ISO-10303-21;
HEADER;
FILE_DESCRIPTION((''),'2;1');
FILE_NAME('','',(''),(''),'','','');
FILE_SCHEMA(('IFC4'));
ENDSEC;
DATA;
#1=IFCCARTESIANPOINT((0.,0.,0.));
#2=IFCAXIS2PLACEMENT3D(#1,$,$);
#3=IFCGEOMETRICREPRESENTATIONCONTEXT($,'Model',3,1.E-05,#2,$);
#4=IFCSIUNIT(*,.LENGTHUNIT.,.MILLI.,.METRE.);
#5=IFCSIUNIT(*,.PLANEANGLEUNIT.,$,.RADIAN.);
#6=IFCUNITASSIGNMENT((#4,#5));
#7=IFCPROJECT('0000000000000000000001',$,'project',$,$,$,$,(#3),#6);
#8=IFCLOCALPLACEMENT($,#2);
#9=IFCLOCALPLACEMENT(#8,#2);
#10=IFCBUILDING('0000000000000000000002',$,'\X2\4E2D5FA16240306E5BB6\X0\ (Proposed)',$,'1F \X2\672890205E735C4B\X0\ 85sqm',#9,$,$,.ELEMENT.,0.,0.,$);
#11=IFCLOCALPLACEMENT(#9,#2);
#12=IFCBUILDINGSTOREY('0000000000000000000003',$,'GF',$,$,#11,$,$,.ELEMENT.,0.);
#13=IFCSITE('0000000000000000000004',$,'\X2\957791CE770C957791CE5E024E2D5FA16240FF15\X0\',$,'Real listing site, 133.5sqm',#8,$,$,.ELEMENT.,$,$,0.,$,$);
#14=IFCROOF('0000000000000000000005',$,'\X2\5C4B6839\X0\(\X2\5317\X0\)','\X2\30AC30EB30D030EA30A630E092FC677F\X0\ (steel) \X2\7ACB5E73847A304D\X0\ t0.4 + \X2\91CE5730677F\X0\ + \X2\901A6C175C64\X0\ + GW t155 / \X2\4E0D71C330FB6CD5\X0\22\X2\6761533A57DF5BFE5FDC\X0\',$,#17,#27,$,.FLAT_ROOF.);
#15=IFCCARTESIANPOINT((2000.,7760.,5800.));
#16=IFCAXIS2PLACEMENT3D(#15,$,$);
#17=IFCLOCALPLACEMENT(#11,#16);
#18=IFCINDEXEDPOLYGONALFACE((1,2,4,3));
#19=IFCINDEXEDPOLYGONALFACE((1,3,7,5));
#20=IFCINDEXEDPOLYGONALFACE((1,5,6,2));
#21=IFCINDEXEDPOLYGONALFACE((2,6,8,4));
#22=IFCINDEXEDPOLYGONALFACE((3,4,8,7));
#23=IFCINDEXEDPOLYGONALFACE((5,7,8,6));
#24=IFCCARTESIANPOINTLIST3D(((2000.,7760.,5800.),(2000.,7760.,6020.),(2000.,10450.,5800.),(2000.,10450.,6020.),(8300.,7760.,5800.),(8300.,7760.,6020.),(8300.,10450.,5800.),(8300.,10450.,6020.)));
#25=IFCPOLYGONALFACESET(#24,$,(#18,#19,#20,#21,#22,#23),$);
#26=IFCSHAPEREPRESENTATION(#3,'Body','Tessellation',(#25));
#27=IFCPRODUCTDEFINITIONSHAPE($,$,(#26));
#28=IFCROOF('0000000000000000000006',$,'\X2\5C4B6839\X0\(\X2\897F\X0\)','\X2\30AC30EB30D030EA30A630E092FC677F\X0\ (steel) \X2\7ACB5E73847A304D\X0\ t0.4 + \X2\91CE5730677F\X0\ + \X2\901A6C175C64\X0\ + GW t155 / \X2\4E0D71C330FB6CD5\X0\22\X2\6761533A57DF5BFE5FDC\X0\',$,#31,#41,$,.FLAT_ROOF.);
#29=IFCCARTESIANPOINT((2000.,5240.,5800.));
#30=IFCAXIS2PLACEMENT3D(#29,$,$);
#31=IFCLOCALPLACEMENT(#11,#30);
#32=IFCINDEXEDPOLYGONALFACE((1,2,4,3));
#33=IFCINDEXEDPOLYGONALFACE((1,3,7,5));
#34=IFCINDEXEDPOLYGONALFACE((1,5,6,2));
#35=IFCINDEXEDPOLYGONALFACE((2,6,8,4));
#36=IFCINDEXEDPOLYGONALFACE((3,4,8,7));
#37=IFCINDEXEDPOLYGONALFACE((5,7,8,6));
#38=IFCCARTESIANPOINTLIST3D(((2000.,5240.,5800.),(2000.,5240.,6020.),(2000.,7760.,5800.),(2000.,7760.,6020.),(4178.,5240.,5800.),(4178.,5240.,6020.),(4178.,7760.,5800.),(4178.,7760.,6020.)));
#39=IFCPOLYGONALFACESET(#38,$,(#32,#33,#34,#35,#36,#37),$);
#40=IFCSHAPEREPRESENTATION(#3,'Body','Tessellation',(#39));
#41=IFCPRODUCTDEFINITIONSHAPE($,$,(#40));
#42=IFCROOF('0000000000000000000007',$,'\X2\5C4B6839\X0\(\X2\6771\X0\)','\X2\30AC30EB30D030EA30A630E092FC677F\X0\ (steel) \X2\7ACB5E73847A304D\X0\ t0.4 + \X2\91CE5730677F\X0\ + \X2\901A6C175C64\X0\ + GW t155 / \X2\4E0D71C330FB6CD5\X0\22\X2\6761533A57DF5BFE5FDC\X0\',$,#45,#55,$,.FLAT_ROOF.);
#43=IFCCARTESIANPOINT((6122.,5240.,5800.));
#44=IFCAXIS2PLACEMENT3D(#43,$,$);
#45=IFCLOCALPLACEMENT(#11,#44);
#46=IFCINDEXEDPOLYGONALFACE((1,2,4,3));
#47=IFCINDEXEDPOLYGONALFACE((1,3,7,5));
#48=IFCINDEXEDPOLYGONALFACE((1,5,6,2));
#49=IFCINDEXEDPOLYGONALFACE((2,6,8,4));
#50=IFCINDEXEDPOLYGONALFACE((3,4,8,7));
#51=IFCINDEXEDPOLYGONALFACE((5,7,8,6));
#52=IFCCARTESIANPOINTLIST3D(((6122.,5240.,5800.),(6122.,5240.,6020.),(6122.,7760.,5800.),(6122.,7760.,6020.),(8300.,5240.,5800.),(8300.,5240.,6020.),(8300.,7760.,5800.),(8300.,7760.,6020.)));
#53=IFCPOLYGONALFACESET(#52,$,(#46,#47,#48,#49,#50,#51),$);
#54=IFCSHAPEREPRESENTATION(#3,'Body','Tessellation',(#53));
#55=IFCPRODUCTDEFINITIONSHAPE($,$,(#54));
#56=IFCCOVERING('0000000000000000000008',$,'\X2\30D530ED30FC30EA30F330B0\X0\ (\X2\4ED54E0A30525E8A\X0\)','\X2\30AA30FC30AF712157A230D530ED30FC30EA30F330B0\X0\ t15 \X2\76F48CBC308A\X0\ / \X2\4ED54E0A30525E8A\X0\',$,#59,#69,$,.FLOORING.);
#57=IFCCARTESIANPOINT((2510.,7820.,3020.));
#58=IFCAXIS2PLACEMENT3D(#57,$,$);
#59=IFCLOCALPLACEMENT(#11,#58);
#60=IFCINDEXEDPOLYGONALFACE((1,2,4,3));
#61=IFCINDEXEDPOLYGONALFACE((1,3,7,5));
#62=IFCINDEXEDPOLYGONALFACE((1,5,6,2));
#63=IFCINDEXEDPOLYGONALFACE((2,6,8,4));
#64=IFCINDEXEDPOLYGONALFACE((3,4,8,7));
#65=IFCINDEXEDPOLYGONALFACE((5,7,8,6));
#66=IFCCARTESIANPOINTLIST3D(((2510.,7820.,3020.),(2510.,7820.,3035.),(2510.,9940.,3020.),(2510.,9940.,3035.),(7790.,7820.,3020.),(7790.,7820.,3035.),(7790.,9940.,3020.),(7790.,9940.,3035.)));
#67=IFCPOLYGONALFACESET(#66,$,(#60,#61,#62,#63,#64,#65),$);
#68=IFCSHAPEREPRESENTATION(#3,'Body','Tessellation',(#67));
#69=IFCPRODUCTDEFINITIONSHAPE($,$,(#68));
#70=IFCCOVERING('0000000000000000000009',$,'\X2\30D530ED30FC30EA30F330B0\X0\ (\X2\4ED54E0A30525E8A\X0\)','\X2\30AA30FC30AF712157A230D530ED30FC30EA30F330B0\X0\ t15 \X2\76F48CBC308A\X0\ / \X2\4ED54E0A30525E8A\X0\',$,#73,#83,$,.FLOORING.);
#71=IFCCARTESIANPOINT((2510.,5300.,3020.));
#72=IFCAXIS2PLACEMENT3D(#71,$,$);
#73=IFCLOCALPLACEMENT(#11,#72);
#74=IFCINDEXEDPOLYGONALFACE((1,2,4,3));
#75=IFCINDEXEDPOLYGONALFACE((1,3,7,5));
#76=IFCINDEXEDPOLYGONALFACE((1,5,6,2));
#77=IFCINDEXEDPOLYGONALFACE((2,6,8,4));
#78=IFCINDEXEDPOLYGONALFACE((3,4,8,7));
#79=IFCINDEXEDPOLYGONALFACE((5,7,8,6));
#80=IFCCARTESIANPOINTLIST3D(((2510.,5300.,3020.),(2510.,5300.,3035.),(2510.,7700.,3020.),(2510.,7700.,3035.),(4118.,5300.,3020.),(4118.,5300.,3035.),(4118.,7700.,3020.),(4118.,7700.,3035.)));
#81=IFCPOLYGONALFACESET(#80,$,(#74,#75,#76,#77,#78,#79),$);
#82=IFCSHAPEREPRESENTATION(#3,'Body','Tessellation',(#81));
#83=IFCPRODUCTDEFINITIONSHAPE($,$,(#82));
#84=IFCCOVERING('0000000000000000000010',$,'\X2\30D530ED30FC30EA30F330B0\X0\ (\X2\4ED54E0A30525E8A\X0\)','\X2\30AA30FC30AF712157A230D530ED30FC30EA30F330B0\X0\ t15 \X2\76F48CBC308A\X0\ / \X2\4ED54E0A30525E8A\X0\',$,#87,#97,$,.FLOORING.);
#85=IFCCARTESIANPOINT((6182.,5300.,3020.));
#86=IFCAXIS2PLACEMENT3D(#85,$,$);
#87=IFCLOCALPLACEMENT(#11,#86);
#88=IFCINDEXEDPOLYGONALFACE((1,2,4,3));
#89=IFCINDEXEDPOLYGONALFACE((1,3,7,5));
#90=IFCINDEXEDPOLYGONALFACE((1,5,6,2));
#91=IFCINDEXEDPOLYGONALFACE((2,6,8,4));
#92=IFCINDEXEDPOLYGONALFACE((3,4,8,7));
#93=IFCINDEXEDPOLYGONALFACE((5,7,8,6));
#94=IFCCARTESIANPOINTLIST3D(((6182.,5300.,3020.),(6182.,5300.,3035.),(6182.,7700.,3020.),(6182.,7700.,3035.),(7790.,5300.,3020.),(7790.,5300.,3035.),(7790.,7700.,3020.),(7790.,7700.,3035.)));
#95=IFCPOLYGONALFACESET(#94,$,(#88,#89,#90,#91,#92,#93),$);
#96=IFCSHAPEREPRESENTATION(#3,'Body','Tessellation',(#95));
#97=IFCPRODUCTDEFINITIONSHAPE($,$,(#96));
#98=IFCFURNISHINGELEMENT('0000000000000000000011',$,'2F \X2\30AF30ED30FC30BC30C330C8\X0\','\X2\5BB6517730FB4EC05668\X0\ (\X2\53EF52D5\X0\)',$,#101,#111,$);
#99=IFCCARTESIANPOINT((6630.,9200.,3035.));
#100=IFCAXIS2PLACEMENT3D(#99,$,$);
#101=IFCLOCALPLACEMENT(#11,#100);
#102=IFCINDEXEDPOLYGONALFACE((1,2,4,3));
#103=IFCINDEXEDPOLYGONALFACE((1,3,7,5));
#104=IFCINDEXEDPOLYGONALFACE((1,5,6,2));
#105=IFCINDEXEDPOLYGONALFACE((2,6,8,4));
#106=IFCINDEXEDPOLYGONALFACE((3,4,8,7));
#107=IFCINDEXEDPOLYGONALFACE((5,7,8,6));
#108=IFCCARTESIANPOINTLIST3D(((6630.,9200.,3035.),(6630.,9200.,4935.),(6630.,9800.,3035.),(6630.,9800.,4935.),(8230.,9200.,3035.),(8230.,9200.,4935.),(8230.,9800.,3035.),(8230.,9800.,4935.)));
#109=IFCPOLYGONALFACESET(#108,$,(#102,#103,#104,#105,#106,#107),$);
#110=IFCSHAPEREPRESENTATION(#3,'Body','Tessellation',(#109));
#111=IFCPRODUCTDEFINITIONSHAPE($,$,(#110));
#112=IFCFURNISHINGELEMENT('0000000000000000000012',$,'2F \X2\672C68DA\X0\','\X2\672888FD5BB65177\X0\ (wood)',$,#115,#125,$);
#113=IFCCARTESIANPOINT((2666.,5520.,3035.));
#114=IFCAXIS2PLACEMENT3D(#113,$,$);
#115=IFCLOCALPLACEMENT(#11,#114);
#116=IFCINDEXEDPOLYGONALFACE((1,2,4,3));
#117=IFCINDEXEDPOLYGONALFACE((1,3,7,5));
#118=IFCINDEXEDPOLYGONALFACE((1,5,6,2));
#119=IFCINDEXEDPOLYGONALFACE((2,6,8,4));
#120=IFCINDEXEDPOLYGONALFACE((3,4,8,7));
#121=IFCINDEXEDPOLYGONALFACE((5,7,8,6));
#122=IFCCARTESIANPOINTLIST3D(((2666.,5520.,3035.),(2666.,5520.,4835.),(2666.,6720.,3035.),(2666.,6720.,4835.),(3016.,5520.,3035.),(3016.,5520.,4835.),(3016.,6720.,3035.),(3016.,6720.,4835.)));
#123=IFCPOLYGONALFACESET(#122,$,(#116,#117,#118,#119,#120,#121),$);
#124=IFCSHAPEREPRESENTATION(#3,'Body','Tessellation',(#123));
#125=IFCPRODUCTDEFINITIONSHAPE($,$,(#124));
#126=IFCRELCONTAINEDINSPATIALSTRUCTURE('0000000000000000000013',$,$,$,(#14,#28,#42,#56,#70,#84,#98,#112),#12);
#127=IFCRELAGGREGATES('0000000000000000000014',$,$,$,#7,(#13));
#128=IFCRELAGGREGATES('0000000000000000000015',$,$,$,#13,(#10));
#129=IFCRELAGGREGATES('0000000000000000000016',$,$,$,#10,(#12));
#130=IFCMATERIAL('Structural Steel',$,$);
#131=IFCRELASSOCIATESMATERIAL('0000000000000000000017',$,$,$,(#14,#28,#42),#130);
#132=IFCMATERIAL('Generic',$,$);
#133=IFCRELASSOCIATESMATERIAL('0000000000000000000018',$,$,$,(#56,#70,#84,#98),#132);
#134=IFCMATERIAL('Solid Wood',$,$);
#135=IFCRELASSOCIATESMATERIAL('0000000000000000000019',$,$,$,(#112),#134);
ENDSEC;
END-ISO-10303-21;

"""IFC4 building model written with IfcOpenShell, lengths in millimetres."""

from ifc_helpers import new_model, si_unit, frame, frame_2d, origin, place, context, project, spatial, rectangle, extrude, material, element, save


model = new_model("IFC4")

# Units and contexts
model_context = context("Model", 3, precision=1e-05, world=origin())
ifc_project = project(units=[si_unit("LENGTHUNIT", "METRE", prefix="MILLI"), si_unit("PLANEANGLEUNIT", "RADIAN")], contexts=[model_context])

# Site, building, storey
site_placement = place(None, origin())
site = spatial("IfcSite", under=ifc_project, at=site_placement, Name="長野県長野市中御所５", ObjectType="Real listing site, 133.5sqm", CompositionType="ELEMENT", RefElevation=0.0)
building_placement = place(site_placement, origin())
building = spatial("IfcBuilding", under=site, at=building_placement, Name="中御所の家 (Proposed)", ObjectType="1F 木造平屋 85sqm", CompositionType="ELEMENT", ElevationOfRefHeight=0.0, ElevationOfTerrain=0.0)
storey_placement = place(building_placement, origin())
storey = spatial("IfcBuildingStorey", under=building, at=storey_placement, Name="GF", CompositionType="ELEMENT", Elevation=0.0)

# Shared definitions
ifc_material_1 = material(Name="Solid Wood")

# Shared definitions
ifc_material_2 = material(Name="Generic")

# Roofs
ifc_material_3 = material(Name="Structural Steel")
for number, where, name in (
    (1, (2000.0, 7760.0, 5800.0), "屋根(北)"),
):
    element("IfcRoof", number, at=place(storey_placement, frame(where)), inside=storey, material=ifc_material_3, Name=name, Description="ガルバリウム鋼板 (steel) 立平葺き t0.4 + 野地板 + 通気層 + GW t155 / 不燃・法22条区域対応", PredefinedType="FLAT_ROOF", context=model_context, shape_type="SweptSolid", body=[
        extrude(rectangle(XDim=6300.0, YDim=2690.0, at=frame_2d((3150.0, 1345.0))), frame((2000.0, 7760.0, 5800.0)), (0.0, 0.0, 1.0), 220.0),
    ])
roof_1_placement = place(storey_placement, frame((2000.0, 5240.0, 5800.0)))
element("IfcRoof", 2, at=roof_1_placement, inside=storey, material=ifc_material_3, Name="屋根(西)", Description="ガルバリウム鋼板 (steel) 立平葺き t0.4 + 野地板 + 通気層 + GW t155 / 不燃・法22条区域対応", PredefinedType="FLAT_ROOF", context=model_context, shape_type="SweptSolid", body=[
    extrude(rectangle(XDim=2178.0, YDim=2520.0, at=frame_2d((1089.0, 1260.0))), frame((2000.0, 5240.0, 5800.0)), (0.0, 0.0, 1.0), 220.0),
])
roof_2_placement = place(storey_placement, frame((6122.0, 5240.0, 5800.0)))
element("IfcRoof", 3, at=roof_2_placement, inside=storey, material=ifc_material_3, Name="屋根(東)", Description="ガルバリウム鋼板 (steel) 立平葺き t0.4 + 野地板 + 通気層 + GW t155 / 不燃・法22条区域対応", PredefinedType="FLAT_ROOF", context=model_context, shape_type="SweptSolid", body=[
    extrude(rectangle(XDim=2178.0, YDim=2520.0, at=frame_2d((1089.0, 1260.0))), frame((6122.0, 5240.0, 5800.0)), (0.0, 0.0, 1.0), 220.0),
])

# Coverings
covering_1_placement = place(storey_placement, frame((2510.0, 7820.0, 3020.0)))
element("IfcCovering", 4, at=covering_1_placement, inside=storey, material=ifc_material_2, Name="フローリング (仕上げ床)", Description="オーク無垢フローリング t15 直貼り / 仕上げ床", PredefinedType="FLOORING", context=model_context, shape_type="SweptSolid", body=[
    extrude(rectangle(XDim=5280.0, YDim=2120.0, at=frame_2d((2640.0, 1060.0))), frame((2510.0, 7820.0, 3020.0)), (0.0, 0.0, 1.0), 15.0),
])
covering_2_placement = place(storey_placement, frame((2510.0, 5300.0, 3020.0)))
element("IfcCovering", 5, at=covering_2_placement, inside=storey, material=ifc_material_2, Name="フローリング (仕上げ床)", Description="オーク無垢フローリング t15 直貼り / 仕上げ床", PredefinedType="FLOORING", context=model_context, shape_type="SweptSolid", body=[
    extrude(rectangle(XDim=1608.0, YDim=2400.0, at=frame_2d((804.0, 1200.0))), frame((2510.0, 5300.0, 3020.0)), (0.0, 0.0, 1.0), 15.0),
])
covering_3_placement = place(storey_placement, frame((6182.0, 5300.0, 3020.0)))
element("IfcCovering", 6, at=covering_3_placement, inside=storey, material=ifc_material_2, Name="フローリング (仕上げ床)", Description="オーク無垢フローリング t15 直貼り / 仕上げ床", PredefinedType="FLOORING", context=model_context, shape_type="SweptSolid", body=[
    extrude(rectangle(XDim=1608.0, YDim=2400.0, at=frame_2d((804.0, 1200.0))), frame((6182.0, 5300.0, 3020.0)), (0.0, 0.0, 1.0), 15.0),
])

# Furnishing elements
furnishing_1_placement = place(storey_placement, frame((6630.0, 9200.0, 3035.0)))
element("IfcFurnishingElement", 7, at=furnishing_1_placement, inside=storey, material=ifc_material_2, Name="2F クローゼット", Description="家具・什器 (可動)", context=model_context, shape_type="SweptSolid", body=[
    extrude(rectangle(XDim=1600.0, YDim=600.0, at=frame_2d((800.0, 300.0))), frame((6630.0, 9200.0, 3035.0)), (0.0, 0.0, 1.0), 1900.0),
])
furnishing_2_placement = place(storey_placement, frame((2666.0, 5520.0, 3035.0)))
element("IfcFurnishingElement", 8, at=furnishing_2_placement, inside=storey, material=ifc_material_1, Name="2F 本棚", Description="木製家具 (wood)", context=model_context, shape_type="SweptSolid", body=[
    extrude(rectangle(XDim=350.0, YDim=1200.0, at=frame_2d((175.0, 600.0))), frame((2666.0, 5520.0, 3035.0)), (0.0, 0.0, 1.0), 1800.0),
])

save(model, "model.ifc")
